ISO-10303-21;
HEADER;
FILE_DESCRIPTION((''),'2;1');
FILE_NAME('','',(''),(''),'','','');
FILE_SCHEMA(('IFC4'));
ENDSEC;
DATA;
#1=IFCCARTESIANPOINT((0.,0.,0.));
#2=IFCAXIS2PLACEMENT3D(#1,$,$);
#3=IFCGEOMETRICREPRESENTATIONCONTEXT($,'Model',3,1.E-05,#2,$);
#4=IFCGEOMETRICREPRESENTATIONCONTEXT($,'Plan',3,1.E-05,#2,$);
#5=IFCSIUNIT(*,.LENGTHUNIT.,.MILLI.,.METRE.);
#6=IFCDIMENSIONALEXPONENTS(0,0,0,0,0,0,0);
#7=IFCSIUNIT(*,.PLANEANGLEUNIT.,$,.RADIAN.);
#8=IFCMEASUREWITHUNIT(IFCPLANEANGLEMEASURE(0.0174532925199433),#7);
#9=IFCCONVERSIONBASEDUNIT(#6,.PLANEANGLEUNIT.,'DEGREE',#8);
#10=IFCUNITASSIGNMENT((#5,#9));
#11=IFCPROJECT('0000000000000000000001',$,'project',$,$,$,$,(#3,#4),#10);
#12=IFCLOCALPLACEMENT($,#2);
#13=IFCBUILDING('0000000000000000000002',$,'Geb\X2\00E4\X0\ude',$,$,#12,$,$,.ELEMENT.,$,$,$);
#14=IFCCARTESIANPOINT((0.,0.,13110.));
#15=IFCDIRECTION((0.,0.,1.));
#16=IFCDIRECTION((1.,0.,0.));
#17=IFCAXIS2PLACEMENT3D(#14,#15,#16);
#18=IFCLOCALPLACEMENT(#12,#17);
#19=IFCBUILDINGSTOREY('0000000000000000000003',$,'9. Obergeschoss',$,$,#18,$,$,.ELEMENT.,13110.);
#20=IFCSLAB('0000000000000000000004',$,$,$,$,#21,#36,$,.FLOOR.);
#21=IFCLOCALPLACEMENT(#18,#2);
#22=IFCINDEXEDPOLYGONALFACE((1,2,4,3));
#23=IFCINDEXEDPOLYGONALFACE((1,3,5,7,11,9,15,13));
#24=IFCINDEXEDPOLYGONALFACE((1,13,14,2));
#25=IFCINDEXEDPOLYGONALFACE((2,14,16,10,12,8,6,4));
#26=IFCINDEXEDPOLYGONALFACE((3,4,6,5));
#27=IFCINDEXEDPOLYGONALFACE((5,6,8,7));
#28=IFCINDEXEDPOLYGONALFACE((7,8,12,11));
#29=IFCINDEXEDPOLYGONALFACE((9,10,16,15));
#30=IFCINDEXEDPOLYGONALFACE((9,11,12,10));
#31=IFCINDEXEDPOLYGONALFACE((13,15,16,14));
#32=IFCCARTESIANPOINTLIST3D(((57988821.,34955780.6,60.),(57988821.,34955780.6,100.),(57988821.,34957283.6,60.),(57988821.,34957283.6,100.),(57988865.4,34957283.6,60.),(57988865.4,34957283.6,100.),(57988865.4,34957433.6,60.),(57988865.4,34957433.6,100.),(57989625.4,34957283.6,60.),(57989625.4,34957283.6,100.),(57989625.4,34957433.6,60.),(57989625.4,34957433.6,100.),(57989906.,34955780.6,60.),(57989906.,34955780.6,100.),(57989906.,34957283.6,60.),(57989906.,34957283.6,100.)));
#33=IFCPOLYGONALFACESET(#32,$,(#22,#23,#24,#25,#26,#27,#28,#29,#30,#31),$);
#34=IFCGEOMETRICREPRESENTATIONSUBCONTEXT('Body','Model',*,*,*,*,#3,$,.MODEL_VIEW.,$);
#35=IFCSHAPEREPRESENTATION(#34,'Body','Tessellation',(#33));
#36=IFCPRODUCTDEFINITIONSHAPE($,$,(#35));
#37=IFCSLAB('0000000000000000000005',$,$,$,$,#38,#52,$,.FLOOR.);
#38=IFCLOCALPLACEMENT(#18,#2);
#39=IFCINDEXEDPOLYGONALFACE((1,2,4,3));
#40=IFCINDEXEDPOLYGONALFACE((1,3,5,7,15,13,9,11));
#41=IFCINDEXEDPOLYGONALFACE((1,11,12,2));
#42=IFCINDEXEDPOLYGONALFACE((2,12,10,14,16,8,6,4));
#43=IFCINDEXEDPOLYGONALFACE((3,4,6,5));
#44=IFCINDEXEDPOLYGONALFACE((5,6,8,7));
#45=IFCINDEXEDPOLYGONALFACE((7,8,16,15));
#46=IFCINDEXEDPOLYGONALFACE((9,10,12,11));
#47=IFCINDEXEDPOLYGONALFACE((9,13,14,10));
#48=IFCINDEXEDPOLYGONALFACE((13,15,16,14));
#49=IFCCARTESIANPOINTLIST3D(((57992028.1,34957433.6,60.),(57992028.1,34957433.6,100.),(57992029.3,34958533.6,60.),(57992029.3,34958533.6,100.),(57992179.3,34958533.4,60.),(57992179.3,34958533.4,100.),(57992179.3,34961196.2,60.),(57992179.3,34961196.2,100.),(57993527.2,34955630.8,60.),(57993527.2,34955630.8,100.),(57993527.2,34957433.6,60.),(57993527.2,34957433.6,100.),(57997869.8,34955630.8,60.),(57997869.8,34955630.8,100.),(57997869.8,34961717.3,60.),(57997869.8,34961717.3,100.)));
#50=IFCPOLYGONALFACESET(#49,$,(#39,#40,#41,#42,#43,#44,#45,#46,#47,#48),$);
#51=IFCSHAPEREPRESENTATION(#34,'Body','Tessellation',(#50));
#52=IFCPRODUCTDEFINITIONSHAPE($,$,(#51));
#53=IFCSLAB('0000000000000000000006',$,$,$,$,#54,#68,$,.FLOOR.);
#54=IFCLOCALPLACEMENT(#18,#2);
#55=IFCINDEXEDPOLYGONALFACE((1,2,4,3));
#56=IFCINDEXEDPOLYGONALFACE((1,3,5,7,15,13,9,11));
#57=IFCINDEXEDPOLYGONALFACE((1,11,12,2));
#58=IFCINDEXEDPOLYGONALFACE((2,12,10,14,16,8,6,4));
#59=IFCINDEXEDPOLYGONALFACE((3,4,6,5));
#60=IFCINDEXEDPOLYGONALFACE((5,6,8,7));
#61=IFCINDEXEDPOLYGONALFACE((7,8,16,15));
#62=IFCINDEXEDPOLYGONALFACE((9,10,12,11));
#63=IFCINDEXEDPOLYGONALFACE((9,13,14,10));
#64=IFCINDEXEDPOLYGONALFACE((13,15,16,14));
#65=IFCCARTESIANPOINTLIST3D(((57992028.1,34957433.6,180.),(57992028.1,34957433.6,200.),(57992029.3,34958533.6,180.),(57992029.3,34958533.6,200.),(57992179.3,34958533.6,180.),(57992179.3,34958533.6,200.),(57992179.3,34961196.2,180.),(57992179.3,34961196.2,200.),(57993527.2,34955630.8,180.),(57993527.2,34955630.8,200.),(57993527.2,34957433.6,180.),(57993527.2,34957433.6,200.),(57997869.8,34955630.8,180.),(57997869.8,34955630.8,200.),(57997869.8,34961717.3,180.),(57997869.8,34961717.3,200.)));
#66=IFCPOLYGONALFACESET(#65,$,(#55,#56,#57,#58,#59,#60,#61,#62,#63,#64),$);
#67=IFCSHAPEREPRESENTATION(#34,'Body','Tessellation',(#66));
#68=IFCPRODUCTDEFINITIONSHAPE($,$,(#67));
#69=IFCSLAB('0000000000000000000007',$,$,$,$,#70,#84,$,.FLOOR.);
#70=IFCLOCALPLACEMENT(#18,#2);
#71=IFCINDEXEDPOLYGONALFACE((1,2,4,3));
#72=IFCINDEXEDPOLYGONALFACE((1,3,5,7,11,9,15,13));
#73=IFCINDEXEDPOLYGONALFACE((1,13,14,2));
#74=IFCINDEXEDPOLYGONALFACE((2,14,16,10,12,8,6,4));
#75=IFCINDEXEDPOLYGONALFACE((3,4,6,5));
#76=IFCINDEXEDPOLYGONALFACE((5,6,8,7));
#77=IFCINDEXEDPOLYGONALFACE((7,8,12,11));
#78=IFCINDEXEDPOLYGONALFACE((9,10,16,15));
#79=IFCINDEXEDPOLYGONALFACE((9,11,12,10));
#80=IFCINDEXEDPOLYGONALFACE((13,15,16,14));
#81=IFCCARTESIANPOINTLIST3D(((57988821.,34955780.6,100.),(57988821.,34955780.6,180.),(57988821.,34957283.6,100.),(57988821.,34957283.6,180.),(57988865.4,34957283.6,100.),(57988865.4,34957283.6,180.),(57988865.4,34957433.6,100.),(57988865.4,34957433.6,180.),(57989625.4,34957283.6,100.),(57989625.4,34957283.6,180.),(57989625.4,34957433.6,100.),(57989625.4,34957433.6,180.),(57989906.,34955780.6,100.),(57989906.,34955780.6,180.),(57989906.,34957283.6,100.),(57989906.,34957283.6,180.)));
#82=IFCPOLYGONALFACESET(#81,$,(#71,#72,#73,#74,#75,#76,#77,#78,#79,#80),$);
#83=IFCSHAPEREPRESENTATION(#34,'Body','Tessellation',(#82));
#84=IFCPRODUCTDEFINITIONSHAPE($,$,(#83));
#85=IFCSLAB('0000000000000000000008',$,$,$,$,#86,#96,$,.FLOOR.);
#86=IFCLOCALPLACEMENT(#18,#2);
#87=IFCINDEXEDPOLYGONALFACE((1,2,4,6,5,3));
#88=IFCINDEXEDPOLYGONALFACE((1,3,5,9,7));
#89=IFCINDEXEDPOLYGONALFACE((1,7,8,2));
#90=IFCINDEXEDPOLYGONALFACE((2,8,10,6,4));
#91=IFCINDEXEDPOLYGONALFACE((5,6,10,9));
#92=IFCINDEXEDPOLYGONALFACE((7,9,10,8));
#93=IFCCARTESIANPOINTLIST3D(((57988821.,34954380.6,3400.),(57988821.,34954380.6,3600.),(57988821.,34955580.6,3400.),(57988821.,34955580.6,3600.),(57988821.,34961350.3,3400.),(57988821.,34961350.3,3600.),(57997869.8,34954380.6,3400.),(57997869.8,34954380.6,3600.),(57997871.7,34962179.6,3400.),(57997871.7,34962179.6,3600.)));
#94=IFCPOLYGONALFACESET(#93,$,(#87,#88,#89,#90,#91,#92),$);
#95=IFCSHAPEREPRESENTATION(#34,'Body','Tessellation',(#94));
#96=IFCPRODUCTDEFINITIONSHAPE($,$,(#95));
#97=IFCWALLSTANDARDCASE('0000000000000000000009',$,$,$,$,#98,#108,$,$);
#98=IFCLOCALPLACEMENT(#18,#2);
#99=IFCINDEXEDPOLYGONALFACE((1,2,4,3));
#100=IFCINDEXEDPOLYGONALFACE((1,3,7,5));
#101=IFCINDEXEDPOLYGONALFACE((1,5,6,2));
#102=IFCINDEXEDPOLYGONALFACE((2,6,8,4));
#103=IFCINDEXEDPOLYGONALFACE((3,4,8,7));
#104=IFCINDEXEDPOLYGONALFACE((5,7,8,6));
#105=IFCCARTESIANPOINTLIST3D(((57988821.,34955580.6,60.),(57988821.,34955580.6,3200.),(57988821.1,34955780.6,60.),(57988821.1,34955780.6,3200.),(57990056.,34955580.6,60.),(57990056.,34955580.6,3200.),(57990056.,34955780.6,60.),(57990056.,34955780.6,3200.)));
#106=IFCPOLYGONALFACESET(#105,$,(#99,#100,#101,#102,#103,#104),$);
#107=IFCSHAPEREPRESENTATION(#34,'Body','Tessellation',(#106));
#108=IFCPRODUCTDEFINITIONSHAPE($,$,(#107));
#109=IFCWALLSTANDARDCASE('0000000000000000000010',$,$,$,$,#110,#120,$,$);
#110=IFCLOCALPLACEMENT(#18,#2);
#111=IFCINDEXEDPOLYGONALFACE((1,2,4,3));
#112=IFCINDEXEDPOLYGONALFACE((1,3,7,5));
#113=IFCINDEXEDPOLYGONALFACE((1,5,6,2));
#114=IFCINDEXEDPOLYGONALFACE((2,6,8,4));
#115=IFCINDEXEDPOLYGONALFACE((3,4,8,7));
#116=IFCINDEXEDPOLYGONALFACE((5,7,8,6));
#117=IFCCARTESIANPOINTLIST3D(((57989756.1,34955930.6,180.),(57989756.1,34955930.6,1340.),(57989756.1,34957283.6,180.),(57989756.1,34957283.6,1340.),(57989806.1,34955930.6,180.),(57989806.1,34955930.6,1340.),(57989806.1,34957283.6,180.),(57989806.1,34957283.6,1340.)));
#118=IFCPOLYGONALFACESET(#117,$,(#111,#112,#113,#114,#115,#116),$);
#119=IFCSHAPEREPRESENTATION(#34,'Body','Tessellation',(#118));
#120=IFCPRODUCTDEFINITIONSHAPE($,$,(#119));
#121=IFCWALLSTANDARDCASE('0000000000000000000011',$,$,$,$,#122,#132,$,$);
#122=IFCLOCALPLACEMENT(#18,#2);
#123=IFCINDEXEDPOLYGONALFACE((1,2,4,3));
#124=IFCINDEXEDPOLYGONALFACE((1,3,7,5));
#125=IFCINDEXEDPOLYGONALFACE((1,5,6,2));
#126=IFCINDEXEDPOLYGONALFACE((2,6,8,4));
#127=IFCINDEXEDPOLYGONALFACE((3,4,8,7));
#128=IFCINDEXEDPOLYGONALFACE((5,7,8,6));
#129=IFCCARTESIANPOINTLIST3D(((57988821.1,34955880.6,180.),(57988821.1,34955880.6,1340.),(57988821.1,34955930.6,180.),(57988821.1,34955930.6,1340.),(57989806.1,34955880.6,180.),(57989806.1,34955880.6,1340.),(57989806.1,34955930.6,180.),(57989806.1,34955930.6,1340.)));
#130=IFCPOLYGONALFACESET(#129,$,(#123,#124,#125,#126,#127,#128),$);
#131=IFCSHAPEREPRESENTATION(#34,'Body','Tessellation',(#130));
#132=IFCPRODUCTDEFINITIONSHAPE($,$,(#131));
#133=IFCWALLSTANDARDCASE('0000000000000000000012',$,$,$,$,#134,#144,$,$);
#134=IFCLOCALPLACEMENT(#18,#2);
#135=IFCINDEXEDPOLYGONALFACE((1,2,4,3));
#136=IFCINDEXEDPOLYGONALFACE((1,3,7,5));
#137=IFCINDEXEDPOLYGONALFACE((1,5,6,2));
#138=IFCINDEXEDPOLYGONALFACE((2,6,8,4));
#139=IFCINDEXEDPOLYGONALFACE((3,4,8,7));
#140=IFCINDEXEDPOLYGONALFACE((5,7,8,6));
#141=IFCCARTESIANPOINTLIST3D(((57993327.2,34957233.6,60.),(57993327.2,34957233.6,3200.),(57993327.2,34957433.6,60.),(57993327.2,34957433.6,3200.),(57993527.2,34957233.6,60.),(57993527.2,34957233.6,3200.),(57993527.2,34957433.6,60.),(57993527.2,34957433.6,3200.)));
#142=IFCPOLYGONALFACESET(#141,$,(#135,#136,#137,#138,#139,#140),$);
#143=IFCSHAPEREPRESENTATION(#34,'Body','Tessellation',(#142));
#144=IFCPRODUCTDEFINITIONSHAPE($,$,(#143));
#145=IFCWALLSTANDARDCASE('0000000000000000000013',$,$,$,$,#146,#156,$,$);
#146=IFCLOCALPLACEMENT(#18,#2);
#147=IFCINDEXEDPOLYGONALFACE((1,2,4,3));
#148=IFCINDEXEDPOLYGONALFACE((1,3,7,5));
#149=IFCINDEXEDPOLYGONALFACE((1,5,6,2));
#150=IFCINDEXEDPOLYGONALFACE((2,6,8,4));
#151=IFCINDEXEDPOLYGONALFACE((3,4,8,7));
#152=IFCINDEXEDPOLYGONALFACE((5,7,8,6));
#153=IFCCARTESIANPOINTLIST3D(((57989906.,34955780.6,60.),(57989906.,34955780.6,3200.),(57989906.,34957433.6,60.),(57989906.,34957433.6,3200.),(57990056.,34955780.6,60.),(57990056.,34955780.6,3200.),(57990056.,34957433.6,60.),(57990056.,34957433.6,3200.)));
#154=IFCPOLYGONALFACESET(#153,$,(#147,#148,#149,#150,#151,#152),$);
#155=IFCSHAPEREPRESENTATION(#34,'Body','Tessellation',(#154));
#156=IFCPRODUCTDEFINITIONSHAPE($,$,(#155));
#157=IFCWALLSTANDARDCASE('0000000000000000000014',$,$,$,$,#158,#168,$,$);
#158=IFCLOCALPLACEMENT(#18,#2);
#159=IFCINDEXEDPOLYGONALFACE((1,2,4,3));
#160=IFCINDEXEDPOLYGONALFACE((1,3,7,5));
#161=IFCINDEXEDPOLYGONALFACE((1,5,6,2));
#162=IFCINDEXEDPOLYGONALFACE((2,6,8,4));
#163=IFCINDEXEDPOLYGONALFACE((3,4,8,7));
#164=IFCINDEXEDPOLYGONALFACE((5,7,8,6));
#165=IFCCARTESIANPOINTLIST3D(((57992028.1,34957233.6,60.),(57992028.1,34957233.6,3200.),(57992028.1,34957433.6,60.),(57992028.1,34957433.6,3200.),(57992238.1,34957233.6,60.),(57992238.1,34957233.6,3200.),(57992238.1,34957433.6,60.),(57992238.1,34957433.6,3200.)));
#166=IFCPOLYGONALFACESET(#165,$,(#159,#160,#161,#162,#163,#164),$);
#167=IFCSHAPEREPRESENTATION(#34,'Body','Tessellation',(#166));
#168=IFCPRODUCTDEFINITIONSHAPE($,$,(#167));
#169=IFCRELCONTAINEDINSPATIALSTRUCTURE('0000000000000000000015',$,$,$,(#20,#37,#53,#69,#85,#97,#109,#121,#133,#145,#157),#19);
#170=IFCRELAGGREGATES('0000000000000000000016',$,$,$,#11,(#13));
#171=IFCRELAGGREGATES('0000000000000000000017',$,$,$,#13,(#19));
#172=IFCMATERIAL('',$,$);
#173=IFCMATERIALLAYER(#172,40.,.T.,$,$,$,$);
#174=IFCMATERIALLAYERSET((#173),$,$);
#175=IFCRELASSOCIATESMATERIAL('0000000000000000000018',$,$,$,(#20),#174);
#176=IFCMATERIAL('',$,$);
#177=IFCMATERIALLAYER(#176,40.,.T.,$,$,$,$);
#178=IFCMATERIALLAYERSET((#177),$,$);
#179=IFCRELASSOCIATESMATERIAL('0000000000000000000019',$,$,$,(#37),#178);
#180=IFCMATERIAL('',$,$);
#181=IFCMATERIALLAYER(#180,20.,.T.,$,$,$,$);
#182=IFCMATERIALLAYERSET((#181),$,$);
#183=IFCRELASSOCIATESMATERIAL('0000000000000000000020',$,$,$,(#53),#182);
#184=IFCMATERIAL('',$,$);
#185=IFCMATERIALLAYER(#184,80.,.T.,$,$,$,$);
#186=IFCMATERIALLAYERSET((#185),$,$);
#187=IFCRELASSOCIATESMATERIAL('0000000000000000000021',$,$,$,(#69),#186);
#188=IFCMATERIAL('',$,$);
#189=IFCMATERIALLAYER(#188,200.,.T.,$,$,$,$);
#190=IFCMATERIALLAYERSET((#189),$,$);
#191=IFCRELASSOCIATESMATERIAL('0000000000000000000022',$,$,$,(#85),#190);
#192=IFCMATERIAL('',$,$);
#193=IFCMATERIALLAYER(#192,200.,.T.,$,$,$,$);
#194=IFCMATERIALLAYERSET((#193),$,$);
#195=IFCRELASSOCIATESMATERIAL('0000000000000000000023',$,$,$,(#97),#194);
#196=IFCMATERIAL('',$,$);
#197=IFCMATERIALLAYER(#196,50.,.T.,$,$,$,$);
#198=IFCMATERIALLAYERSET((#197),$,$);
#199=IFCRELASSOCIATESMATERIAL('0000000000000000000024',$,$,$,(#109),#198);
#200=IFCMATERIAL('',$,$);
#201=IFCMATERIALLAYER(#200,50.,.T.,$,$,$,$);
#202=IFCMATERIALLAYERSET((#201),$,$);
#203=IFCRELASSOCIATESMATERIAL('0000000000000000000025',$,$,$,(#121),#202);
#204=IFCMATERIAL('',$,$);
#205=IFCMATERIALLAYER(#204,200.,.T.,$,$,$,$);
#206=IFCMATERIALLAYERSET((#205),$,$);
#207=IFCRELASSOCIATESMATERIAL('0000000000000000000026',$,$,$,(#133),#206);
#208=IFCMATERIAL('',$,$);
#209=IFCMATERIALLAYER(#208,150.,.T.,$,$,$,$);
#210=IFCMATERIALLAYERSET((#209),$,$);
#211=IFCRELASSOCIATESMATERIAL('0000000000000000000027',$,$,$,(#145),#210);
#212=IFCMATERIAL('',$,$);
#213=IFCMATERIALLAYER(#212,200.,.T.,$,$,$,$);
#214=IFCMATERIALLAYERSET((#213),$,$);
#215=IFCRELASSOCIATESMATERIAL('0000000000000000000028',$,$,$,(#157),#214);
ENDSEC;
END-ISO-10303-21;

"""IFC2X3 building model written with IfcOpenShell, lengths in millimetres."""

from ifc_helpers import new_model, entity, si_unit, converted_unit, frame, frame_2d, origin, origin_with_axes, place, context, subcontext, project, spatial, polyline, rectangle, outline, extrude, material, layer, layer_set, layer_usage, element, save


model = new_model("IFC2X3")

# Units and contexts
model_context = context("Model", 3, precision=1e-05, world=origin())
plan_context = context("Plan", 3, precision=1e-05, world=origin())
body_context = subcontext(model_context, "Body", "Model", "MODEL_VIEW")
ifc_project = project(units=[si_unit("LENGTHUNIT", "METRE", prefix="MILLI"), converted_unit("PLANEANGLEUNIT", "DEGREE", entity("IfcPlaneAngleMeasure", 0.0174532925199433), si_unit("PLANEANGLEUNIT", "RADIAN"), dimensions=[0, 0, 0, 0, 0, 0, 0])], contexts=[model_context, plan_context])

# Building, storey
building_placement = place(None, origin())
building = spatial("IfcBuilding", under=ifc_project, at=building_placement, Name="Gebäude", CompositionType="ELEMENT")
storey_placement = place(building_placement, frame((0.0, 0.0, 13110.0), z_axis=(0.0, 0.0, 1.0), x_axis=(1.0, 0.0, 0.0)))
storey = spatial("IfcBuildingStorey", under=building, at=storey_placement, Name="9. Obergeschoss", CompositionType="ELEMENT", Elevation=13110.0)

# Slabs
ifc_material_1 = material(Name="")
ifc_layer_1 = layer(ifc_material_1, 40.0, ventilated=True)
ifc_layer_set_1 = layer_set([ifc_layer_1])
ifc_layer_usage_1 = layer_usage(ifc_layer_set_1, "AXIS3", "POSITIVE", 0.0)
slab_1_placement = place(storey_placement, frame((57988821.0, 34955780.6, 60.0), z_axis=(0.0, 0.0, 1.0), x_axis=(1.0, 0.0, 0.0)))
element("IfcSlab", 1, at=slab_1_placement, inside=storey, material=ifc_layer_usage_1, PredefinedType="FLOOR", context=body_context, shape_type="SweptSolid", body=[
    extrude(outline(polyline([(0.0, 0.0), (1085.0, 0.0), (1085.0, 1503.0), (804.3, 1503.0), (804.3, 1653.0), (44.3, 1653.0), (44.3, 1503.0), (0.0, 1503.0), (0.0, 0.0)])), origin_with_axes(), (0.0, 0.0, 1.0), 40.0),
])
ifc_material_2 = material(Name="")
ifc_layer_2 = layer(ifc_material_2, 40.0, ventilated=True)
ifc_layer_set_2 = layer_set([ifc_layer_2])
ifc_layer_usage_2 = layer_usage(ifc_layer_set_2, "AXIS3", "POSITIVE", 0.0)
slab_2_placement = place(storey_placement, frame((57992028.1, 34955630.8, 60.0), z_axis=(0.0, 0.0, 1.0), x_axis=(1.0, 0.0, 0.0)))
element("IfcSlab", 2, at=slab_2_placement, inside=storey, material=ifc_layer_usage_2, PredefinedType="FLOOR", context=body_context, shape_type="SweptSolid", body=[
    extrude(outline(polyline([(0.0, 1802.7), (1499.1, 1802.7), (1499.1, 0.0), (5841.7, 0.0), (5841.7, 6086.5), (151.2, 5565.3), (151.2, 2902.6), (1.2, 2902.7), (0.0, 1802.7)])), origin_with_axes(), (0.0, 0.0, 1.0), 40.0),
])
ifc_material_3 = material(Name="")
ifc_layer_3 = layer(ifc_material_3, 20.0, ventilated=True)
ifc_layer_set_3 = layer_set([ifc_layer_3])
ifc_layer_usage_3 = layer_usage(ifc_layer_set_3, "AXIS3", "POSITIVE", 0.0)
slab_3_placement = place(storey_placement, frame((57992028.1, 34955630.8, 180.0), z_axis=(0.0, 0.0, 1.0), x_axis=(1.0, 0.0, 0.0)))
element("IfcSlab", 3, at=slab_3_placement, inside=storey, material=ifc_layer_usage_3, PredefinedType="FLOOR", context=body_context, shape_type="SweptSolid", body=[
    extrude(outline(polyline([(0.0, 1802.7), (1499.1, 1802.7), (1499.1, 0.0), (5841.7, 0.0), (5841.7, 6086.5), (151.2, 5565.3), (151.2, 2902.7), (1.2, 2902.7), (0.0, 1802.7)])), origin_with_axes(), (0.0, 0.0, 1.0), 20.0),
])
ifc_material_4 = material(Name="")
ifc_layer_4 = layer(ifc_material_4, 80.0, ventilated=True)
ifc_layer_set_4 = layer_set([ifc_layer_4])
ifc_layer_usage_4 = layer_usage(ifc_layer_set_4, "AXIS3", "POSITIVE", 0.0)
slab_4_placement = place(storey_placement, frame((57988821.0, 34955780.6, 100.0), z_axis=(0.0, 0.0, 1.0), x_axis=(1.0, 0.0, 0.0)))
element("IfcSlab", 4, at=slab_4_placement, inside=storey, material=ifc_layer_usage_4, PredefinedType="FLOOR", context=body_context, shape_type="SweptSolid", body=[
    extrude(outline(polyline([(0.0, 0.0), (1085.0, 0.0), (1085.0, 1503.0), (804.3, 1503.0), (804.3, 1653.0), (44.3, 1653.0), (44.3, 1503.0), (0.0, 1503.0), (0.0, 0.0)])), origin_with_axes(), (0.0, 0.0, 1.0), 80.0),
])
ifc_material_5 = material(Name="")
ifc_layer_5 = layer(ifc_material_5, 200.0, ventilated=True)
ifc_layer_set_5 = layer_set([ifc_layer_5])
ifc_layer_usage_5 = layer_usage(ifc_layer_set_5, "AXIS3", "POSITIVE", 0.0)
slab_5_placement = place(storey_placement, frame((57988821.0, 34954380.6, 3400.0), z_axis=(0.0, 0.0, 1.0), x_axis=(1.0, 0.0, 0.0)))
element("IfcSlab", 5, at=slab_5_placement, inside=storey, material=ifc_layer_usage_5, PredefinedType="FLOOR", context=body_context, shape_type="SweptSolid", body=[
    extrude(outline(polyline([(0.0, 1200.0), (0.0, 0.0), (9048.8, 0.0), (9050.7, 7799.1), (0.0, 6969.7), (0.0, 1200.0)])), origin_with_axes(), (0.0, 0.0, 1.0), 200.0),
])

# Walls
ifc_material_6 = material(Name="")
ifc_layer_6 = layer(ifc_material_6, 200.0, ventilated=True)
ifc_layer_set_6 = layer_set([ifc_layer_6])
ifc_layer_usage_6 = layer_usage(ifc_layer_set_6, "AXIS2", "POSITIVE", 0.0)
wall_1_placement = place(storey_placement, frame((57988821.0, 34955580.6, 60.0), z_axis=(0.0, 0.0, 1.0), x_axis=(1.0, 0.0, 0.0)))
element("IfcWallStandardCase", 6, at=wall_1_placement, inside=storey, material=ifc_layer_usage_6, context=body_context, shape_type="SweptSolid", body=[
    extrude(outline(polyline([(0.0, 0.0), (1235.0, 0.0), (1235.0, 200.0), (0.0, 200.0), (0.0, 0.0)])), origin_with_axes(), (0.0, 0.0, 1.0), 3140.0),
])
ifc_material_7 = material(Name="")
ifc_layer_7 = layer(ifc_material_7, 50.0, ventilated=True)
ifc_layer_set_7 = layer_set([ifc_layer_7])
ifc_layer_usage_7 = layer_usage(ifc_layer_set_7, "AXIS2", "POSITIVE", 0.0)
wall_2_placement = place(storey_placement, frame((57989756.1, 34957283.6, 180.0), z_axis=(0.0, 0.0, 1.0), x_axis=(0.0, -1.0, 0.0)))
element("IfcWallStandardCase", 7, at=wall_2_placement, inside=storey, material=ifc_layer_usage_7, context=body_context, shape_type="SweptSolid", body=[
    extrude(rectangle(XDim=1353.0, YDim=50.0, at=frame_2d((676.5, 25.0), x_axis=(1.0, 0.0))), origin_with_axes(), (0.0, 0.0, 1.0), 1160.0),
])
ifc_material_8 = material(Name="")
ifc_layer_8 = layer(ifc_material_8, 50.0, ventilated=True)
ifc_layer_set_8 = layer_set([ifc_layer_8])
ifc_layer_usage_8 = layer_usage(ifc_layer_set_8, "AXIS2", "POSITIVE", 0.0)
wall_3_placement = place(storey_placement, frame((57989806.1, 34955930.6, 180.0), z_axis=(0.0, 0.0, 1.0), x_axis=(-1.0, 0.0, 0.0)))
element("IfcWallStandardCase", 8, at=wall_3_placement, inside=storey, material=ifc_layer_usage_8, context=body_context, shape_type="SweptSolid", body=[
    extrude(rectangle(XDim=985.0, YDim=50.0, at=frame_2d((492.5, 25.0), x_axis=(1.0, 0.0))), origin_with_axes(), (0.0, 0.0, 1.0), 1160.0),
])
ifc_material_9 = material(Name="")
ifc_layer_9 = layer(ifc_material_9, 200.0, ventilated=True)
ifc_layer_set_9 = layer_set([ifc_layer_9])
ifc_layer_usage_9 = layer_usage(ifc_layer_set_9, "AXIS2", "POSITIVE", 0.0)
wall_4_placement = place(storey_placement, frame((57993327.2, 34957233.6, 60.0), z_axis=(0.0, 0.0, 1.0), x_axis=(1.0, 0.0, 0.0)))
element("IfcWallStandardCase", 9, at=wall_4_placement, inside=storey, material=ifc_layer_usage_9, context=body_context, shape_type="SweptSolid", body=[
    extrude(rectangle(XDim=200.0, YDim=200.0, at=frame_2d((100.0, 100.0), x_axis=(1.0, 0.0))), origin_with_axes(), (0.0, 0.0, 1.0), 3140.0),
])
ifc_material_10 = material(Name="")
ifc_layer_10 = layer(ifc_material_10, 150.0, ventilated=True)
ifc_layer_set_10 = layer_set([ifc_layer_10])
ifc_layer_usage_10 = layer_usage(ifc_layer_set_10, "AXIS2", "POSITIVE", 0.0)
wall_5_placement = place(storey_placement, frame((57990056.0, 34955780.6, 60.0), z_axis=(0.0, 0.0, 1.0), x_axis=(0.0, 1.0, 0.0)))
element("IfcWallStandardCase", 10, at=wall_5_placement, inside=storey, material=ifc_layer_usage_10, context=body_context, shape_type="SweptSolid", body=[
    extrude(rectangle(XDim=1653.0, YDim=150.0, at=frame_2d((826.5, 75.0), x_axis=(1.0, 0.0))), origin_with_axes(), (0.0, 0.0, 1.0), 3140.0),
])
ifc_material_11 = material(Name="")
ifc_layer_11 = layer(ifc_material_11, 200.0, ventilated=True)
ifc_layer_set_11 = layer_set([ifc_layer_11])
ifc_layer_usage_11 = layer_usage(ifc_layer_set_11, "AXIS2", "POSITIVE", 0.0)
wall_6_placement = place(storey_placement, frame((57992028.1, 34957233.6, 60.0), z_axis=(0.0, 0.0, 1.0), x_axis=(1.0, 0.0, 0.0)))
element("IfcWallStandardCase", 11, at=wall_6_placement, inside=storey, material=ifc_layer_usage_11, context=body_context, shape_type="SweptSolid", body=[
    extrude(rectangle(XDim=210.0, YDim=200.0, at=frame_2d((105.0, 100.0), x_axis=(1.0, 0.0))), origin_with_axes(), (0.0, 0.0, 1.0), 3140.0),
])

save(model, "model.ifc")
